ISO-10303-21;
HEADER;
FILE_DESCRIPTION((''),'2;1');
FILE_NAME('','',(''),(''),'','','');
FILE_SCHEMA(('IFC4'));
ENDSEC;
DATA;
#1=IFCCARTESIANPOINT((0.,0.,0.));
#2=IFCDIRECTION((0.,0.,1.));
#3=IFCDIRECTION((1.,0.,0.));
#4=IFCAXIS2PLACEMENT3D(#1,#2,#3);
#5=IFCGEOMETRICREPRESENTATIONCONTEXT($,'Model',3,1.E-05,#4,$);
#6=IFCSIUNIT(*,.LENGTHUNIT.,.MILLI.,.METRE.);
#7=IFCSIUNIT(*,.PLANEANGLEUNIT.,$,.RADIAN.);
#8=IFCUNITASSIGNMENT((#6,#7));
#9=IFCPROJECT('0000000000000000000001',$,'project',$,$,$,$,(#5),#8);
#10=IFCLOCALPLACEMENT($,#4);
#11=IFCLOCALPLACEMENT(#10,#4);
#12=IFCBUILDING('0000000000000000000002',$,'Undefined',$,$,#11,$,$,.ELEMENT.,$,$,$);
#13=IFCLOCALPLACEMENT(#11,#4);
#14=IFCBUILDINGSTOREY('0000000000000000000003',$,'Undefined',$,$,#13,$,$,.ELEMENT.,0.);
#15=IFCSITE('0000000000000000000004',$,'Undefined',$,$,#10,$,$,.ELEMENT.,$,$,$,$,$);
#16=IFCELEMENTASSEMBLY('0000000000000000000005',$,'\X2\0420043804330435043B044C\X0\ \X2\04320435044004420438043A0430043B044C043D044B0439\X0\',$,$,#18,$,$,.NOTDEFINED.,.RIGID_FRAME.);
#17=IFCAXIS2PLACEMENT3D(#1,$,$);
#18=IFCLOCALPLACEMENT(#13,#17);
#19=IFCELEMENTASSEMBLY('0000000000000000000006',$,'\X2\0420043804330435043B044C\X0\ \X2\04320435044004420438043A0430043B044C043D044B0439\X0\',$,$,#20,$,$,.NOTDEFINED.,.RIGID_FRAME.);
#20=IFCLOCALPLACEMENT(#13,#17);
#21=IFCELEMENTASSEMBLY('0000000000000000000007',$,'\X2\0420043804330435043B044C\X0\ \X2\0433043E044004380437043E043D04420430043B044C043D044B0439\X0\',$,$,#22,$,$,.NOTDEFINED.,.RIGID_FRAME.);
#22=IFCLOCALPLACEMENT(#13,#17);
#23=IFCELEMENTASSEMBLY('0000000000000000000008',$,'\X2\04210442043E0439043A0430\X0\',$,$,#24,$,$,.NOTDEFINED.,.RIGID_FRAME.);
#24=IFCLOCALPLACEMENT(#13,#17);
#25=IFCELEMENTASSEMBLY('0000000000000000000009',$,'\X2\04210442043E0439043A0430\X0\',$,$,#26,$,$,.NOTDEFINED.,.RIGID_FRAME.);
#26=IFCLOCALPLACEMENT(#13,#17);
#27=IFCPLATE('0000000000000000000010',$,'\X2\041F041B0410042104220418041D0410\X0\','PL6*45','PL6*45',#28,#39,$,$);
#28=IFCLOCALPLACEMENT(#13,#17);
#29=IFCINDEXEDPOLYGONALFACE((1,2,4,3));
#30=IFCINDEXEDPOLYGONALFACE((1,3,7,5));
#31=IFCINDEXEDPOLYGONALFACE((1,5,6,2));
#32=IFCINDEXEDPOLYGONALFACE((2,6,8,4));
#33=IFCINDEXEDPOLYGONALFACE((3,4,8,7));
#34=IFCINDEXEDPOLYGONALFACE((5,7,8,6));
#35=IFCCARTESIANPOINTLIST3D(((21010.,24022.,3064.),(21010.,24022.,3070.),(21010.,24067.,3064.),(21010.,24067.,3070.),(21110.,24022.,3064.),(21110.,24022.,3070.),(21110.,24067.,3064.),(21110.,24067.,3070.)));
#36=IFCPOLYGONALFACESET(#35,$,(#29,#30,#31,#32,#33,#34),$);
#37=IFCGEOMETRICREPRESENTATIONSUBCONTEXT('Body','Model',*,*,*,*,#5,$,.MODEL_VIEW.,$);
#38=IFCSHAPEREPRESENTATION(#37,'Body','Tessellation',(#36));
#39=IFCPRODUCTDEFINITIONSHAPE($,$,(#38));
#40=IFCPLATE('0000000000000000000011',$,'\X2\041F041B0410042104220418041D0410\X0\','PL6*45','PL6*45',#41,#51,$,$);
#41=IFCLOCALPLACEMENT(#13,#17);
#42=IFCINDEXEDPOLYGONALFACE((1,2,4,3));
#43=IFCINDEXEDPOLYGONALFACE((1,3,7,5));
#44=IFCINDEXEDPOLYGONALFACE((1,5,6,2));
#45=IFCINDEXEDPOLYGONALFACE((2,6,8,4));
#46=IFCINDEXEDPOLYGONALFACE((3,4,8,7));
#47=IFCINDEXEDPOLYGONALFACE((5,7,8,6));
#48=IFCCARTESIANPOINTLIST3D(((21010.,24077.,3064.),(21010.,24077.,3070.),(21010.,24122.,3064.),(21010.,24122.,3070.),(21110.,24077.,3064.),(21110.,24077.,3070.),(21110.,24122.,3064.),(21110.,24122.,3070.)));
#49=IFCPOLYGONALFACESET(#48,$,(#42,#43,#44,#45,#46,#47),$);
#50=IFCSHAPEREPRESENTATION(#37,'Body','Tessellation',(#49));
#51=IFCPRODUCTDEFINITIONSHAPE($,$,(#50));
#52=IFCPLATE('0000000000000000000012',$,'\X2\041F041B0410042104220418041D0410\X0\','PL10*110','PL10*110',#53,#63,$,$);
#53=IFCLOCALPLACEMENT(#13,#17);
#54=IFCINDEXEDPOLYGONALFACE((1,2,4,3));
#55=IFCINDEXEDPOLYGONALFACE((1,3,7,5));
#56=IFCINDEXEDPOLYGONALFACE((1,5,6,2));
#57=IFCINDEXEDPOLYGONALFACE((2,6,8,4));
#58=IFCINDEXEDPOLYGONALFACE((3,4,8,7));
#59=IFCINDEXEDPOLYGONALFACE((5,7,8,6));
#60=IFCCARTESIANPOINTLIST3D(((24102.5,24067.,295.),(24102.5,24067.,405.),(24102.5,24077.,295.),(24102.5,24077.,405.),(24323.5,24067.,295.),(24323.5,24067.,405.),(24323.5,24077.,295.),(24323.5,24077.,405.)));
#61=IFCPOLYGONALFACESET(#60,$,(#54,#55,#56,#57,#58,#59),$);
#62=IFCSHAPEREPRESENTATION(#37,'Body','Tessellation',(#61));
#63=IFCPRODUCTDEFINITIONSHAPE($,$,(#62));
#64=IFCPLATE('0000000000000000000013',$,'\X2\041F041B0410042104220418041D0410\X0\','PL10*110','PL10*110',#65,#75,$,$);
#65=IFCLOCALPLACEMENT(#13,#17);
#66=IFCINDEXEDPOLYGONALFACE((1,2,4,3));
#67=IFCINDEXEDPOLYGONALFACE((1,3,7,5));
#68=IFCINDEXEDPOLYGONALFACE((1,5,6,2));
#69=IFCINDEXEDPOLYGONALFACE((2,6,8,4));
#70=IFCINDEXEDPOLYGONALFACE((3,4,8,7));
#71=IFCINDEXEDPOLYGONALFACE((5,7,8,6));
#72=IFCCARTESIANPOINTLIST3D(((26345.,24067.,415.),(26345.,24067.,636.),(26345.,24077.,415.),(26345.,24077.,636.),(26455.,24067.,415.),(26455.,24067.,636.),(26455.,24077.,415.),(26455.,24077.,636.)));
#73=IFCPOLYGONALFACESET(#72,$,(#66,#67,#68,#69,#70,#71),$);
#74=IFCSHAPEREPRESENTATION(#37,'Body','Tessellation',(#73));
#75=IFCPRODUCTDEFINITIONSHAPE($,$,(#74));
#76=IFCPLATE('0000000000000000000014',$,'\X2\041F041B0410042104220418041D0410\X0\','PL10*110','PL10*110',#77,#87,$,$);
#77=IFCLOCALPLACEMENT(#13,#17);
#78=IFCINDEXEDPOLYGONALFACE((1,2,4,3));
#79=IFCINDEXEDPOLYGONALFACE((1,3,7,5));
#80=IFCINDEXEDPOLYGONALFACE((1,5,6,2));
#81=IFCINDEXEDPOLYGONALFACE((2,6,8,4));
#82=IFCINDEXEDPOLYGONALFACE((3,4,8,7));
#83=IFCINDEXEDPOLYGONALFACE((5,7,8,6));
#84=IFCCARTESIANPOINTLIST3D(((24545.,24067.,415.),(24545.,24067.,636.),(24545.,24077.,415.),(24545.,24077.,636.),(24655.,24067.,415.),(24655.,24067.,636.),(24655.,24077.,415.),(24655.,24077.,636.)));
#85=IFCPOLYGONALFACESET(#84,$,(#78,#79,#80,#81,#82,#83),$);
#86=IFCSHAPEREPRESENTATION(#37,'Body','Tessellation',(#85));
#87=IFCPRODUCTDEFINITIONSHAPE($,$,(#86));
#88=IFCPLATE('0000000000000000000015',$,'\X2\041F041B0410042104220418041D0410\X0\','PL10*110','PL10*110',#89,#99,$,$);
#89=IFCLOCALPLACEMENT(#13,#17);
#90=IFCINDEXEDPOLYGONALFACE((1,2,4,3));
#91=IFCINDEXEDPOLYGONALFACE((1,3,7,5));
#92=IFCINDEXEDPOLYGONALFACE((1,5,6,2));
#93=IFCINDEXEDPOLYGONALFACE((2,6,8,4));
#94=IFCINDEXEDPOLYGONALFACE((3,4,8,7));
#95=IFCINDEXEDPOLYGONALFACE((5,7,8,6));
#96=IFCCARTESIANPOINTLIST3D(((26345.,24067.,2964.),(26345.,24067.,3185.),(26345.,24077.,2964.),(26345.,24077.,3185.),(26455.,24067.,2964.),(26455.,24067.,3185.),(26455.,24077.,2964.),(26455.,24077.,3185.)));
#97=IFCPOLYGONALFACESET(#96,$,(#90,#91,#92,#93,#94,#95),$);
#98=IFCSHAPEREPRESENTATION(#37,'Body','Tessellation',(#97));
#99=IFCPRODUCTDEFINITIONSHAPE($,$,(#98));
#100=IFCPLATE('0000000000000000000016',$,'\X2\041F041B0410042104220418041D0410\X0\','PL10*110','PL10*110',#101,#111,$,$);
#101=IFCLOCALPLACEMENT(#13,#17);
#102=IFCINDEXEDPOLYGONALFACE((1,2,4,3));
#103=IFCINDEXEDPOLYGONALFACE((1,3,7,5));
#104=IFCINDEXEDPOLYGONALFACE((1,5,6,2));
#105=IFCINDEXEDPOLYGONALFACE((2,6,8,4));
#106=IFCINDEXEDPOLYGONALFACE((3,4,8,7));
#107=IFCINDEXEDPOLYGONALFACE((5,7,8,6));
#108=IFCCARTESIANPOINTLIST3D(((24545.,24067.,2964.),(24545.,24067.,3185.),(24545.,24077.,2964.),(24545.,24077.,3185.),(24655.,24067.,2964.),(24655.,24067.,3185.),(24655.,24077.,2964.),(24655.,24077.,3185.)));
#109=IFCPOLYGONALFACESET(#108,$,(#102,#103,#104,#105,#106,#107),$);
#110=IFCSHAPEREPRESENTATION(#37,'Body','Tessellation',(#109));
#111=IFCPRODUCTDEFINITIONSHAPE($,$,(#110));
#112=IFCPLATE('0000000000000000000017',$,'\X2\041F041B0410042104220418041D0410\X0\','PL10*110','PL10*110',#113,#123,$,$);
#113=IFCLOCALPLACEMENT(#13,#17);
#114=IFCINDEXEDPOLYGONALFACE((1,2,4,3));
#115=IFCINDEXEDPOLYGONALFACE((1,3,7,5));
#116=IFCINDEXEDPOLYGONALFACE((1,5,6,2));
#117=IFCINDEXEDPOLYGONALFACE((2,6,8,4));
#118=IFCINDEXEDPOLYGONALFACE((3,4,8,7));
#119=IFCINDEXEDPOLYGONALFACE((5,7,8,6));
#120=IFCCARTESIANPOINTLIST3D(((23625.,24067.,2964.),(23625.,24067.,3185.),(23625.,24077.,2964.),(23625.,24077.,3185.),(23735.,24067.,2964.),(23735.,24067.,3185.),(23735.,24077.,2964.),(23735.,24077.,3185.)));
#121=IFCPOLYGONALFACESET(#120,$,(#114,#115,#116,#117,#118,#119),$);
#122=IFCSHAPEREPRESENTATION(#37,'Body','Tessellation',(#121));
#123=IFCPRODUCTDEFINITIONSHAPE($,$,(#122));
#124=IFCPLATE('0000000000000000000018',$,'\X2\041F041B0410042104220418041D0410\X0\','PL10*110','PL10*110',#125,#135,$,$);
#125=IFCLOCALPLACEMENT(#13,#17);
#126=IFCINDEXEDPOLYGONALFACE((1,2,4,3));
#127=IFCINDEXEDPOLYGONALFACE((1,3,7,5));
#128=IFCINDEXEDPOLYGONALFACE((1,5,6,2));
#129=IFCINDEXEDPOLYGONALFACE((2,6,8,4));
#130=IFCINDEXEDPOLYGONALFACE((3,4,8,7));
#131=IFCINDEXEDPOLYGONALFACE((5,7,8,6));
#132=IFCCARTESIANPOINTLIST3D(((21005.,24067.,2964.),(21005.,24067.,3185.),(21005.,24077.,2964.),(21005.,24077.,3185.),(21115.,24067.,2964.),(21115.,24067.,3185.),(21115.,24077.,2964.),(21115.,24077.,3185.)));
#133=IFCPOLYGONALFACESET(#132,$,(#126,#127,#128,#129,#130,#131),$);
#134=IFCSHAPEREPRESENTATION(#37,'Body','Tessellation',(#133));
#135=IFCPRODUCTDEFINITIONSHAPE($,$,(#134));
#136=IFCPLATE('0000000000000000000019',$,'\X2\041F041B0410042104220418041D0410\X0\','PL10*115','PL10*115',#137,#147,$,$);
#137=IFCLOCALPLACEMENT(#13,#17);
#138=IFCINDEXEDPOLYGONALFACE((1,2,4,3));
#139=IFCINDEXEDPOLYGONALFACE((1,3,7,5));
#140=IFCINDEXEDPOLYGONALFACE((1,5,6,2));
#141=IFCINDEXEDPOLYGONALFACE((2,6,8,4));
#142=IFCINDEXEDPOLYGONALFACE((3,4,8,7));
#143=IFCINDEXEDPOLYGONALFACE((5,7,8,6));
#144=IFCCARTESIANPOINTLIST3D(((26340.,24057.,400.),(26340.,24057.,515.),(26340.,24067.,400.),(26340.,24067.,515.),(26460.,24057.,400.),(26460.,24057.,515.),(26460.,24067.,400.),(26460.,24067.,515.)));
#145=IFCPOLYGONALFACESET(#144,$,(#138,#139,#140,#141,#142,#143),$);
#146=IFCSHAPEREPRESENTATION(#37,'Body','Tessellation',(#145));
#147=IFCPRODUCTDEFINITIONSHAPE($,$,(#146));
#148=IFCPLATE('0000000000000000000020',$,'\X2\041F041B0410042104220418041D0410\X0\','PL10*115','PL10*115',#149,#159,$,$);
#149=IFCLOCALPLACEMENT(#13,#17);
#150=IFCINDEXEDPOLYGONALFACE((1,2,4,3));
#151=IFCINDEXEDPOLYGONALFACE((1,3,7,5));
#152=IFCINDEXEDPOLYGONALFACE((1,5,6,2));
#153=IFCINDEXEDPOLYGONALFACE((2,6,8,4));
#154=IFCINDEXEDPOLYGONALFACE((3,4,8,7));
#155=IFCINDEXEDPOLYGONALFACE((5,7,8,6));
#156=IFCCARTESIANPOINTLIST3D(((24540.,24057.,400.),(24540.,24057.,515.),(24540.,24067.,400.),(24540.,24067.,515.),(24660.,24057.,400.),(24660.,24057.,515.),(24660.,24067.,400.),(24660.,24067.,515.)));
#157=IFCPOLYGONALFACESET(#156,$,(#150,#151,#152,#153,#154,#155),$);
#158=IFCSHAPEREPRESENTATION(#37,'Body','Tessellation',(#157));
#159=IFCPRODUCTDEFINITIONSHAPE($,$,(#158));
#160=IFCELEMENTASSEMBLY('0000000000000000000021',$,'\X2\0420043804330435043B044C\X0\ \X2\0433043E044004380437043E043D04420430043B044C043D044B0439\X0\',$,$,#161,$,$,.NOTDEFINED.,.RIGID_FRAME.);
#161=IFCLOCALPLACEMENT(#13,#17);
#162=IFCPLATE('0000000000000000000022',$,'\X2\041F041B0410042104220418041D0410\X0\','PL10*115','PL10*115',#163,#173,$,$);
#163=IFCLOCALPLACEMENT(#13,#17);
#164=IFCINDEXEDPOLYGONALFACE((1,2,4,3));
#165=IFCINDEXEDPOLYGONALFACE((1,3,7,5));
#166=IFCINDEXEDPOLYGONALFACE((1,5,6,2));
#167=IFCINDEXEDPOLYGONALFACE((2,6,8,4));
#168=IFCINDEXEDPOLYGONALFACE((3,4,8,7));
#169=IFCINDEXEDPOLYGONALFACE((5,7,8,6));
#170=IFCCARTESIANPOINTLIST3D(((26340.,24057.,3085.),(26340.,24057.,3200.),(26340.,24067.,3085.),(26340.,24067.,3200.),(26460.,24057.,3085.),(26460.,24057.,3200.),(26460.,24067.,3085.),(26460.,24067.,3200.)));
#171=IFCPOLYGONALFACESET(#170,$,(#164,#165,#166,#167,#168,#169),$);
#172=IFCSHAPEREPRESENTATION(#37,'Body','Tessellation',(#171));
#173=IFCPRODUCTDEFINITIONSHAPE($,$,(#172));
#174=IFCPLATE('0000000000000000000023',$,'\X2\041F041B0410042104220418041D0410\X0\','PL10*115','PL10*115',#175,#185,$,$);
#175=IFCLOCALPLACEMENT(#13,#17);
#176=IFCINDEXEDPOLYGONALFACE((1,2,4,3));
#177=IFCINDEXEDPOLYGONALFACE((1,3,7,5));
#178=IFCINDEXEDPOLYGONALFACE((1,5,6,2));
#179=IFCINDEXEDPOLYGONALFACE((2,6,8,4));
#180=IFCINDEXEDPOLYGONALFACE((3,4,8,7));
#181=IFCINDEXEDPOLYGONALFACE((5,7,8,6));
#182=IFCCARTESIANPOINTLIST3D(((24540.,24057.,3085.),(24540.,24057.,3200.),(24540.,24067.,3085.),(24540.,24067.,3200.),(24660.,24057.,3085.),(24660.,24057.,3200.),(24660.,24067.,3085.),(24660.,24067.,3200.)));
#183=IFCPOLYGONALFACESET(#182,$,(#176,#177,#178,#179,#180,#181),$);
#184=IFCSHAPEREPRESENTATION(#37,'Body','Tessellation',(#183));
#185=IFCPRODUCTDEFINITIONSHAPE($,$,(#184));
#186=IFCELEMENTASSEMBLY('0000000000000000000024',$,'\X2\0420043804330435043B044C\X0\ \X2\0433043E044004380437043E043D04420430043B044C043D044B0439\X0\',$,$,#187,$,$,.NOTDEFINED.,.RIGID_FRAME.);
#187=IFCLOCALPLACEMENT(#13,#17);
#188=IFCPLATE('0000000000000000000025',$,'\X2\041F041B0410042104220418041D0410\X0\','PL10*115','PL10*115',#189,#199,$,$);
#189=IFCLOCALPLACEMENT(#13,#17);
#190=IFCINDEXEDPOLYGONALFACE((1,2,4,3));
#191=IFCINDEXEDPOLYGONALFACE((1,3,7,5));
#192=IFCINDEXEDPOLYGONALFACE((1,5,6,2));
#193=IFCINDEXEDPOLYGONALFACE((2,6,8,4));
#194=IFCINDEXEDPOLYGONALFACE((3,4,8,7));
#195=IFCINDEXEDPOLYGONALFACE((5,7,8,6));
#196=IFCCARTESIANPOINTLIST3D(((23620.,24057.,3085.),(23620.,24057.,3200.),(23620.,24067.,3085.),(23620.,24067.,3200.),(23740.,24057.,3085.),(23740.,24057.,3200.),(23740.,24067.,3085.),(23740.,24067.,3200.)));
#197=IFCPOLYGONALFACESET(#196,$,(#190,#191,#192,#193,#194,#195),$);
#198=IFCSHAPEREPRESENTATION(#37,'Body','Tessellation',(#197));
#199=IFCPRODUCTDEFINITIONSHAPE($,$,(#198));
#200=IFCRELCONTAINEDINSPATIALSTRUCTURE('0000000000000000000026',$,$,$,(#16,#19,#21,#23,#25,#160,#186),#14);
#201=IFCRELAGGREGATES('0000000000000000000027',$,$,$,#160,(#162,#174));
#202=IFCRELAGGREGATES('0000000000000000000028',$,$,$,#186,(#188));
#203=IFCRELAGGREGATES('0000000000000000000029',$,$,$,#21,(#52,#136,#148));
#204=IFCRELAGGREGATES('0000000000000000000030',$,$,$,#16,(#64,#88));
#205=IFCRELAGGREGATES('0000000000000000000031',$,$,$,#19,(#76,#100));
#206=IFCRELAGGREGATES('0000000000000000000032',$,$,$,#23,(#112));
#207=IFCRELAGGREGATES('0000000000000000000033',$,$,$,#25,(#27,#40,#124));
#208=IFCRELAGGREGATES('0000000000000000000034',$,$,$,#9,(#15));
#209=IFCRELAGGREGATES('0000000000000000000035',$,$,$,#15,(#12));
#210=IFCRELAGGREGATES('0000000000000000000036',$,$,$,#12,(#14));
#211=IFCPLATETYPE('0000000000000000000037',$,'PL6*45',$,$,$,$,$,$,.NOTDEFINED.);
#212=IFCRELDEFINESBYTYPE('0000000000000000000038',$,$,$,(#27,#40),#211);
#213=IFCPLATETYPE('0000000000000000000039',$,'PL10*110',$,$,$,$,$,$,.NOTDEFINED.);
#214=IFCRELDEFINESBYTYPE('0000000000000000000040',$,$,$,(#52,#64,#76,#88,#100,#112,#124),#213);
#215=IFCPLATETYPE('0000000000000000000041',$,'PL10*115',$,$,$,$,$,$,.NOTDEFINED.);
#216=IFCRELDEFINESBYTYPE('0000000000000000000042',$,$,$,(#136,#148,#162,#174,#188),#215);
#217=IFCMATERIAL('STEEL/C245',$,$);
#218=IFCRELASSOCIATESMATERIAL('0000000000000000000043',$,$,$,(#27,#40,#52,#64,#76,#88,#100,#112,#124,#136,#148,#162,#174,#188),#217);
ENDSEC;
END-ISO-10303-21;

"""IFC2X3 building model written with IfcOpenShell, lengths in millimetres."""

from ifc_helpers import new_model, si_unit, frame, origin_with_axes, place, context, subcontext, project, spatial, polyline, outline, extrude, material, type_object, element, aggregate, save


model = new_model("IFC2X3")

# Units and contexts
model_context = context("Model", 3, precision=1e-05, world=origin_with_axes())
body_context = subcontext(model_context, "Body", "Model", "MODEL_VIEW")
ifc_project = project(units=[si_unit("LENGTHUNIT", "METRE", prefix="MILLI"), si_unit("PLANEANGLEUNIT", "RADIAN")], contexts=[model_context])

# Site, building, storey
site_placement = place(None, origin_with_axes())
site = spatial("IfcSite", under=ifc_project, at=site_placement, Name="Undefined", CompositionType="ELEMENT")
building_placement = place(site_placement, origin_with_axes())
building = spatial("IfcBuilding", under=site, at=building_placement, Name="Undefined", CompositionType="ELEMENT")
storey_placement = place(building_placement, origin_with_axes())
storey = spatial("IfcBuildingStorey", under=building, at=storey_placement, Name="Undefined", CompositionType="ELEMENT", Elevation=0.0)

# Element assemblies
assembly_1_placement = place(storey_placement, origin_with_axes())
assembly_1 = element("IfcElementAssembly", 1, at=assembly_1_placement, inside=storey, Name="Ригель вертикальный", AssemblyPlace="NOTDEFINED", PredefinedType="RIGID_FRAME")
ifc_material_1 = material(Name="STEEL/C245")
assembly_2_placement = place(storey_placement, origin_with_axes())
assembly_2 = element("IfcElementAssembly", 2, at=assembly_2_placement, inside=storey, Name="Ригель вертикальный", AssemblyPlace="NOTDEFINED", PredefinedType="RIGID_FRAME")

# Element assembly
assembly_3_placement = place(storey_placement, origin_with_axes())
assembly_3 = element("IfcElementAssembly", 3, at=assembly_3_placement, inside=storey, Name="Ригель горизонтальный", AssemblyPlace="NOTDEFINED", PredefinedType="RIGID_FRAME")

# Shared definitions
plate_type_1 = type_object("IfcPlateType", Name="PL6*45", PredefinedType="NOTDEFINED")

# Element assemblies, plates
assembly_4_placement = place(storey_placement, origin_with_axes())
assembly_4 = element("IfcElementAssembly", 4, at=assembly_4_placement, inside=storey, Name="Стойка", AssemblyPlace="NOTDEFINED", PredefinedType="RIGID_FRAME")
assembly_5_placement = place(storey_placement, origin_with_axes())
assembly_5 = element("IfcElementAssembly", 5, at=assembly_5_placement, inside=storey, Name="Стойка", AssemblyPlace="NOTDEFINED", PredefinedType="RIGID_FRAME")
plate_1_placement = place(assembly_5_placement, frame((21110.0, 24044.5, 3067.0), z_axis=(0.0, 0.0, -1.0), x_axis=(-1.0, 0.0, 0.0)))
plate_1 = element("IfcPlate", 6, at=plate_1_placement, type_object=plate_type_1, material=ifc_material_1, Name="ПЛАСТИНА", Description="PL6*45", ObjectType="PL6*45", context=body_context, shape_type="SweptSolid", body=[
    extrude(outline(polyline([(100.0, -22.5), (0.0, -22.5), (0.0, 22.5), (100.0, 22.5), (100.0, -22.5)])), frame((0.0, 0.0, -3.0), z_axis=(0.0, 0.0, 1.0), x_axis=(1.0, 0.0, 0.0)), (0.0, 0.0, 1.0), 6.0),
])
plate_2_placement = place(assembly_5_placement, frame((21110.0, 24099.5, 3067.0), z_axis=(0.0, 0.0, 1.0), x_axis=(-1.0, 0.0, 0.0)))
plate_2 = element("IfcPlate", 7, at=plate_2_placement, type_object=plate_type_1, material=ifc_material_1, Name="ПЛАСТИНА", Description="PL6*45", ObjectType="PL6*45", context=body_context, shape_type="SweptSolid", body=[
    extrude(outline(polyline([(100.0, 22.5), (100.0, -22.5), (0.0, -22.5), (0.0, 22.5), (100.0, 22.5)])), frame((0.0, 0.0, -3.0), z_axis=(0.0, 0.0, 1.0), x_axis=(1.0, 0.0, 0.0)), (0.0, 0.0, 1.0), 6.0),
])

# Plates
plate_type_2 = type_object("IfcPlateType", Name="PL10*110", PredefinedType="NOTDEFINED")
plate_3_placement = place(assembly_3_placement, frame((24102.5, 24072.0, 350.0), z_axis=(0.0, -1.0, 0.0), x_axis=(1.0, 0.0, 0.0)))
plate_3 = element("IfcPlate", 8, at=plate_3_placement, type_object=plate_type_2, material=ifc_material_1, Name="ПЛАСТИНА", Description="PL10*110", ObjectType="PL10*110", context=body_context, shape_type="SweptSolid", body=[
    extrude(outline(polyline([(0.0, -55.0), (0.0, 55.0), (221.0, 55.0), (221.0, -55.0), (0.0, -55.0)])), frame((0.0, 0.0, -5.0), z_axis=(0.0, 0.0, 1.0), x_axis=(1.0, 0.0, 0.0)), (0.0, 0.0, 1.0), 10.0),
])
plate_4_placement = place(assembly_1_placement, frame((26400.0, 24072.0, 415.0), z_axis=(0.0, -1.0, 0.0), x_axis=(0.0, 0.0, 1.0)))
plate_4 = element("IfcPlate", 9, at=plate_4_placement, type_object=plate_type_2, material=ifc_material_1, Name="ПЛАСТИНА", Description="PL10*110", ObjectType="PL10*110", context=body_context, shape_type="SweptSolid", body=[
    extrude(outline(polyline([(0.0, 55.0), (221.0, 55.0), (221.0, -55.0), (0.0, -55.0), (0.0, 55.0)])), frame((0.0, 0.0, -5.0), z_axis=(0.0, 0.0, 1.0), x_axis=(1.0, 0.0, 0.0)), (0.0, 0.0, 1.0), 10.0),
])
plate_5_placement = place(assembly_2_placement, frame((24600.0, 24072.0, 415.0), z_axis=(0.0, -1.0, 0.0), x_axis=(0.0, 0.0, 1.0)))
plate_5 = element("IfcPlate", 10, at=plate_5_placement, type_object=plate_type_2, material=ifc_material_1, Name="ПЛАСТИНА", Description="PL10*110", ObjectType="PL10*110", context=body_context, shape_type="SweptSolid", body=[
    extrude(outline(polyline([(0.0, 55.0), (221.0, 55.0), (221.0, -55.0), (0.0, -55.0), (0.0, 55.0)])), frame((0.0, 0.0, -5.0), z_axis=(0.0, 0.0, 1.0), x_axis=(1.0, 0.0, 0.0)), (0.0, 0.0, 1.0), 10.0),
])
plate_6_placement = place(assembly_1_placement, frame((26400.0, 24072.0, 3185.0), z_axis=(0.0, -1.0, 0.0), x_axis=(0.0, 0.0, -1.0)))
plate_6 = element("IfcPlate", 11, at=plate_6_placement, type_object=plate_type_2, material=ifc_material_1, Name="ПЛАСТИНА", Description="PL10*110", ObjectType="PL10*110", context=body_context, shape_type="SweptSolid", body=[
    extrude(outline(polyline([(221.0, -55.0), (0.0, -55.0), (0.0, 55.0), (221.0, 55.0), (221.0, -55.0)])), frame((0.0, 0.0, -5.0), z_axis=(0.0, 0.0, 1.0), x_axis=(1.0, 0.0, 0.0)), (0.0, 0.0, 1.0), 10.0),
])
plate_7_placement = place(assembly_2_placement, frame((24600.0, 24072.0, 3185.0), z_axis=(0.0, -1.0, 0.0), x_axis=(0.0, 0.0, -1.0)))
plate_7 = element("IfcPlate", 12, at=plate_7_placement, type_object=plate_type_2, material=ifc_material_1, Name="ПЛАСТИНА", Description="PL10*110", ObjectType="PL10*110", context=body_context, shape_type="SweptSolid", body=[
    extrude(outline(polyline([(221.0, -55.0), (0.0, -55.0), (0.0, 55.0), (221.0, 55.0), (221.0, -55.0)])), frame((0.0, 0.0, -5.0), z_axis=(0.0, 0.0, 1.0), x_axis=(1.0, 0.0, 0.0)), (0.0, 0.0, 1.0), 10.0),
])
plate_8_placement = place(assembly_4_placement, frame((23680.0, 24072.0, 3185.0), z_axis=(0.0, -1.0, 0.0), x_axis=(0.0, 0.0, -1.0)))
plate_8 = element("IfcPlate", 13, at=plate_8_placement, type_object=plate_type_2, material=ifc_material_1, Name="ПЛАСТИНА", Description="PL10*110", ObjectType="PL10*110", context=body_context, shape_type="SweptSolid", body=[
    extrude(outline(polyline([(221.0, -55.0), (0.0, -55.0), (0.0, 55.0), (221.0, 55.0), (221.0, -55.0)])), frame((0.0, 0.0, -5.0), z_axis=(0.0, 0.0, 1.0), x_axis=(1.0, 0.0, 0.0)), (0.0, 0.0, 1.0), 10.0),
])
plate_9_placement = place(assembly_5_placement, frame((21060.0, 24072.0, 3185.0), z_axis=(0.0, -1.0, 0.0), x_axis=(0.0, 0.0, -1.0)))
plate_9 = element("IfcPlate", 14, at=plate_9_placement, type_object=plate_type_2, material=ifc_material_1, Name="ПЛАСТИНА", Description="PL10*110", ObjectType="PL10*110", context=body_context, shape_type="SweptSolid", body=[
    extrude(outline(polyline([(221.0, -55.0), (0.0, -55.0), (0.0, 55.0), (221.0, 55.0), (221.0, -55.0)])), frame((0.0, 0.0, -5.0), z_axis=(0.0, 0.0, 1.0), x_axis=(1.0, 0.0, 0.0)), (0.0, 0.0, 1.0), 10.0),
])
plate_type_3 = type_object("IfcPlateType", Name="PL10*115", PredefinedType="NOTDEFINED")
plate_10_placement = place(assembly_3_placement, frame((26460.0, 24062.0, 400.0), z_axis=(0.0, -1.0, 0.0), x_axis=(0.0, 0.0, 1.0)))
plate_10 = element("IfcPlate", 15, at=plate_10_placement, type_object=plate_type_3, material=ifc_material_1, Name="ПЛАСТИНА", Description="PL10*115", ObjectType="PL10*115", context=body_context, shape_type="SweptSolid", body=[
    extrude(outline(polyline([(0.0, 0.0), (115.0, 0.0), (115.0, 120.0), (0.0, 120.0), (0.0, 0.0)])), frame((0.0, 0.0, -5.0), z_axis=(0.0, 0.0, 1.0), x_axis=(1.0, 0.0, 0.0)), (0.0, 0.0, 1.0), 10.0),
])
plate_11_placement = place(assembly_3_placement, frame((24660.0, 24062.0, 400.0), z_axis=(0.0, -1.0, 0.0), x_axis=(0.0, 0.0, 1.0)))
plate_11 = element("IfcPlate", 16, at=plate_11_placement, type_object=plate_type_3, material=ifc_material_1, Name="ПЛАСТИНА", Description="PL10*115", ObjectType="PL10*115", context=body_context, shape_type="SweptSolid", body=[
    extrude(outline(polyline([(0.0, 0.0), (115.0, 0.0), (115.0, 120.0), (0.0, 120.0), (0.0, 0.0)])), frame((0.0, 0.0, -5.0), z_axis=(0.0, 0.0, 1.0), x_axis=(1.0, 0.0, 0.0)), (0.0, 0.0, 1.0), 10.0),
])

# Element assembly, plates
assembly_6_placement = place(storey_placement, origin_with_axes())
assembly_6 = element("IfcElementAssembly", 17, at=assembly_6_placement, inside=storey, Name="Ригель горизонтальный", AssemblyPlace="NOTDEFINED", PredefinedType="RIGID_FRAME")
plate_12_placement = place(assembly_6_placement, frame((26340.0, 24062.0, 3200.0), z_axis=(0.0, -1.0, 0.0), x_axis=(0.0, 0.0, -1.0)))
plate_12 = element("IfcPlate", 18, at=plate_12_placement, type_object=plate_type_3, material=ifc_material_1, Name="ПЛАСТИНА", Description="PL10*115", ObjectType="PL10*115", context=body_context, shape_type="SweptSolid", body=[
    extrude(outline(polyline([(0.0, 0.0), (115.0, 0.0), (115.0, 120.0), (0.0, 120.0), (0.0, 0.0)])), frame((0.0, 0.0, -5.0), z_axis=(0.0, 0.0, 1.0), x_axis=(1.0, 0.0, 0.0)), (0.0, 0.0, 1.0), 10.0),
])
plate_13_placement = place(assembly_6_placement, frame((24540.0, 24062.0, 3200.0), z_axis=(0.0, -1.0, 0.0), x_axis=(0.0, 0.0, -1.0)))
plate_13 = element("IfcPlate", 19, at=plate_13_placement, type_object=plate_type_3, material=ifc_material_1, Name="ПЛАСТИНА", Description="PL10*115", ObjectType="PL10*115", context=body_context, shape_type="SweptSolid", body=[
    extrude(outline(polyline([(0.0, 0.0), (115.0, 0.0), (115.0, 120.0), (0.0, 120.0), (0.0, 0.0)])), frame((0.0, 0.0, -5.0), z_axis=(0.0, 0.0, 1.0), x_axis=(1.0, 0.0, 0.0)), (0.0, 0.0, 1.0), 10.0),
])
aggregate(assembly_6, [plate_12, plate_13])

# Element assembly, plate
assembly_7_placement = place(storey_placement, origin_with_axes())
assembly_7 = element("IfcElementAssembly", 20, at=assembly_7_placement, inside=storey, Name="Ригель горизонтальный", AssemblyPlace="NOTDEFINED", PredefinedType="RIGID_FRAME")
plate_14_placement = place(assembly_7_placement, frame((23620.0, 24062.0, 3200.0), z_axis=(0.0, -1.0, 0.0), x_axis=(0.0, 0.0, -1.0)))
plate_14 = element("IfcPlate", 21, at=plate_14_placement, type_object=plate_type_3, material=ifc_material_1, Name="ПЛАСТИНА", Description="PL10*115", ObjectType="PL10*115", context=body_context, shape_type="SweptSolid", body=[
    extrude(outline(polyline([(0.0, 0.0), (115.0, 0.0), (115.0, 120.0), (0.0, 120.0), (0.0, 0.0)])), frame((0.0, 0.0, -5.0), z_axis=(0.0, 0.0, 1.0), x_axis=(1.0, 0.0, 0.0)), (0.0, 0.0, 1.0), 10.0),
])
aggregate(assembly_7, [plate_14])

aggregate(assembly_3, [plate_3, plate_10, plate_11])
aggregate(assembly_1, [plate_4, plate_6])
aggregate(assembly_2, [plate_5, plate_7])
aggregate(assembly_4, [plate_8])
aggregate(assembly_5, [plate_1, plate_2, plate_9])

save(model, "model.ifc")
